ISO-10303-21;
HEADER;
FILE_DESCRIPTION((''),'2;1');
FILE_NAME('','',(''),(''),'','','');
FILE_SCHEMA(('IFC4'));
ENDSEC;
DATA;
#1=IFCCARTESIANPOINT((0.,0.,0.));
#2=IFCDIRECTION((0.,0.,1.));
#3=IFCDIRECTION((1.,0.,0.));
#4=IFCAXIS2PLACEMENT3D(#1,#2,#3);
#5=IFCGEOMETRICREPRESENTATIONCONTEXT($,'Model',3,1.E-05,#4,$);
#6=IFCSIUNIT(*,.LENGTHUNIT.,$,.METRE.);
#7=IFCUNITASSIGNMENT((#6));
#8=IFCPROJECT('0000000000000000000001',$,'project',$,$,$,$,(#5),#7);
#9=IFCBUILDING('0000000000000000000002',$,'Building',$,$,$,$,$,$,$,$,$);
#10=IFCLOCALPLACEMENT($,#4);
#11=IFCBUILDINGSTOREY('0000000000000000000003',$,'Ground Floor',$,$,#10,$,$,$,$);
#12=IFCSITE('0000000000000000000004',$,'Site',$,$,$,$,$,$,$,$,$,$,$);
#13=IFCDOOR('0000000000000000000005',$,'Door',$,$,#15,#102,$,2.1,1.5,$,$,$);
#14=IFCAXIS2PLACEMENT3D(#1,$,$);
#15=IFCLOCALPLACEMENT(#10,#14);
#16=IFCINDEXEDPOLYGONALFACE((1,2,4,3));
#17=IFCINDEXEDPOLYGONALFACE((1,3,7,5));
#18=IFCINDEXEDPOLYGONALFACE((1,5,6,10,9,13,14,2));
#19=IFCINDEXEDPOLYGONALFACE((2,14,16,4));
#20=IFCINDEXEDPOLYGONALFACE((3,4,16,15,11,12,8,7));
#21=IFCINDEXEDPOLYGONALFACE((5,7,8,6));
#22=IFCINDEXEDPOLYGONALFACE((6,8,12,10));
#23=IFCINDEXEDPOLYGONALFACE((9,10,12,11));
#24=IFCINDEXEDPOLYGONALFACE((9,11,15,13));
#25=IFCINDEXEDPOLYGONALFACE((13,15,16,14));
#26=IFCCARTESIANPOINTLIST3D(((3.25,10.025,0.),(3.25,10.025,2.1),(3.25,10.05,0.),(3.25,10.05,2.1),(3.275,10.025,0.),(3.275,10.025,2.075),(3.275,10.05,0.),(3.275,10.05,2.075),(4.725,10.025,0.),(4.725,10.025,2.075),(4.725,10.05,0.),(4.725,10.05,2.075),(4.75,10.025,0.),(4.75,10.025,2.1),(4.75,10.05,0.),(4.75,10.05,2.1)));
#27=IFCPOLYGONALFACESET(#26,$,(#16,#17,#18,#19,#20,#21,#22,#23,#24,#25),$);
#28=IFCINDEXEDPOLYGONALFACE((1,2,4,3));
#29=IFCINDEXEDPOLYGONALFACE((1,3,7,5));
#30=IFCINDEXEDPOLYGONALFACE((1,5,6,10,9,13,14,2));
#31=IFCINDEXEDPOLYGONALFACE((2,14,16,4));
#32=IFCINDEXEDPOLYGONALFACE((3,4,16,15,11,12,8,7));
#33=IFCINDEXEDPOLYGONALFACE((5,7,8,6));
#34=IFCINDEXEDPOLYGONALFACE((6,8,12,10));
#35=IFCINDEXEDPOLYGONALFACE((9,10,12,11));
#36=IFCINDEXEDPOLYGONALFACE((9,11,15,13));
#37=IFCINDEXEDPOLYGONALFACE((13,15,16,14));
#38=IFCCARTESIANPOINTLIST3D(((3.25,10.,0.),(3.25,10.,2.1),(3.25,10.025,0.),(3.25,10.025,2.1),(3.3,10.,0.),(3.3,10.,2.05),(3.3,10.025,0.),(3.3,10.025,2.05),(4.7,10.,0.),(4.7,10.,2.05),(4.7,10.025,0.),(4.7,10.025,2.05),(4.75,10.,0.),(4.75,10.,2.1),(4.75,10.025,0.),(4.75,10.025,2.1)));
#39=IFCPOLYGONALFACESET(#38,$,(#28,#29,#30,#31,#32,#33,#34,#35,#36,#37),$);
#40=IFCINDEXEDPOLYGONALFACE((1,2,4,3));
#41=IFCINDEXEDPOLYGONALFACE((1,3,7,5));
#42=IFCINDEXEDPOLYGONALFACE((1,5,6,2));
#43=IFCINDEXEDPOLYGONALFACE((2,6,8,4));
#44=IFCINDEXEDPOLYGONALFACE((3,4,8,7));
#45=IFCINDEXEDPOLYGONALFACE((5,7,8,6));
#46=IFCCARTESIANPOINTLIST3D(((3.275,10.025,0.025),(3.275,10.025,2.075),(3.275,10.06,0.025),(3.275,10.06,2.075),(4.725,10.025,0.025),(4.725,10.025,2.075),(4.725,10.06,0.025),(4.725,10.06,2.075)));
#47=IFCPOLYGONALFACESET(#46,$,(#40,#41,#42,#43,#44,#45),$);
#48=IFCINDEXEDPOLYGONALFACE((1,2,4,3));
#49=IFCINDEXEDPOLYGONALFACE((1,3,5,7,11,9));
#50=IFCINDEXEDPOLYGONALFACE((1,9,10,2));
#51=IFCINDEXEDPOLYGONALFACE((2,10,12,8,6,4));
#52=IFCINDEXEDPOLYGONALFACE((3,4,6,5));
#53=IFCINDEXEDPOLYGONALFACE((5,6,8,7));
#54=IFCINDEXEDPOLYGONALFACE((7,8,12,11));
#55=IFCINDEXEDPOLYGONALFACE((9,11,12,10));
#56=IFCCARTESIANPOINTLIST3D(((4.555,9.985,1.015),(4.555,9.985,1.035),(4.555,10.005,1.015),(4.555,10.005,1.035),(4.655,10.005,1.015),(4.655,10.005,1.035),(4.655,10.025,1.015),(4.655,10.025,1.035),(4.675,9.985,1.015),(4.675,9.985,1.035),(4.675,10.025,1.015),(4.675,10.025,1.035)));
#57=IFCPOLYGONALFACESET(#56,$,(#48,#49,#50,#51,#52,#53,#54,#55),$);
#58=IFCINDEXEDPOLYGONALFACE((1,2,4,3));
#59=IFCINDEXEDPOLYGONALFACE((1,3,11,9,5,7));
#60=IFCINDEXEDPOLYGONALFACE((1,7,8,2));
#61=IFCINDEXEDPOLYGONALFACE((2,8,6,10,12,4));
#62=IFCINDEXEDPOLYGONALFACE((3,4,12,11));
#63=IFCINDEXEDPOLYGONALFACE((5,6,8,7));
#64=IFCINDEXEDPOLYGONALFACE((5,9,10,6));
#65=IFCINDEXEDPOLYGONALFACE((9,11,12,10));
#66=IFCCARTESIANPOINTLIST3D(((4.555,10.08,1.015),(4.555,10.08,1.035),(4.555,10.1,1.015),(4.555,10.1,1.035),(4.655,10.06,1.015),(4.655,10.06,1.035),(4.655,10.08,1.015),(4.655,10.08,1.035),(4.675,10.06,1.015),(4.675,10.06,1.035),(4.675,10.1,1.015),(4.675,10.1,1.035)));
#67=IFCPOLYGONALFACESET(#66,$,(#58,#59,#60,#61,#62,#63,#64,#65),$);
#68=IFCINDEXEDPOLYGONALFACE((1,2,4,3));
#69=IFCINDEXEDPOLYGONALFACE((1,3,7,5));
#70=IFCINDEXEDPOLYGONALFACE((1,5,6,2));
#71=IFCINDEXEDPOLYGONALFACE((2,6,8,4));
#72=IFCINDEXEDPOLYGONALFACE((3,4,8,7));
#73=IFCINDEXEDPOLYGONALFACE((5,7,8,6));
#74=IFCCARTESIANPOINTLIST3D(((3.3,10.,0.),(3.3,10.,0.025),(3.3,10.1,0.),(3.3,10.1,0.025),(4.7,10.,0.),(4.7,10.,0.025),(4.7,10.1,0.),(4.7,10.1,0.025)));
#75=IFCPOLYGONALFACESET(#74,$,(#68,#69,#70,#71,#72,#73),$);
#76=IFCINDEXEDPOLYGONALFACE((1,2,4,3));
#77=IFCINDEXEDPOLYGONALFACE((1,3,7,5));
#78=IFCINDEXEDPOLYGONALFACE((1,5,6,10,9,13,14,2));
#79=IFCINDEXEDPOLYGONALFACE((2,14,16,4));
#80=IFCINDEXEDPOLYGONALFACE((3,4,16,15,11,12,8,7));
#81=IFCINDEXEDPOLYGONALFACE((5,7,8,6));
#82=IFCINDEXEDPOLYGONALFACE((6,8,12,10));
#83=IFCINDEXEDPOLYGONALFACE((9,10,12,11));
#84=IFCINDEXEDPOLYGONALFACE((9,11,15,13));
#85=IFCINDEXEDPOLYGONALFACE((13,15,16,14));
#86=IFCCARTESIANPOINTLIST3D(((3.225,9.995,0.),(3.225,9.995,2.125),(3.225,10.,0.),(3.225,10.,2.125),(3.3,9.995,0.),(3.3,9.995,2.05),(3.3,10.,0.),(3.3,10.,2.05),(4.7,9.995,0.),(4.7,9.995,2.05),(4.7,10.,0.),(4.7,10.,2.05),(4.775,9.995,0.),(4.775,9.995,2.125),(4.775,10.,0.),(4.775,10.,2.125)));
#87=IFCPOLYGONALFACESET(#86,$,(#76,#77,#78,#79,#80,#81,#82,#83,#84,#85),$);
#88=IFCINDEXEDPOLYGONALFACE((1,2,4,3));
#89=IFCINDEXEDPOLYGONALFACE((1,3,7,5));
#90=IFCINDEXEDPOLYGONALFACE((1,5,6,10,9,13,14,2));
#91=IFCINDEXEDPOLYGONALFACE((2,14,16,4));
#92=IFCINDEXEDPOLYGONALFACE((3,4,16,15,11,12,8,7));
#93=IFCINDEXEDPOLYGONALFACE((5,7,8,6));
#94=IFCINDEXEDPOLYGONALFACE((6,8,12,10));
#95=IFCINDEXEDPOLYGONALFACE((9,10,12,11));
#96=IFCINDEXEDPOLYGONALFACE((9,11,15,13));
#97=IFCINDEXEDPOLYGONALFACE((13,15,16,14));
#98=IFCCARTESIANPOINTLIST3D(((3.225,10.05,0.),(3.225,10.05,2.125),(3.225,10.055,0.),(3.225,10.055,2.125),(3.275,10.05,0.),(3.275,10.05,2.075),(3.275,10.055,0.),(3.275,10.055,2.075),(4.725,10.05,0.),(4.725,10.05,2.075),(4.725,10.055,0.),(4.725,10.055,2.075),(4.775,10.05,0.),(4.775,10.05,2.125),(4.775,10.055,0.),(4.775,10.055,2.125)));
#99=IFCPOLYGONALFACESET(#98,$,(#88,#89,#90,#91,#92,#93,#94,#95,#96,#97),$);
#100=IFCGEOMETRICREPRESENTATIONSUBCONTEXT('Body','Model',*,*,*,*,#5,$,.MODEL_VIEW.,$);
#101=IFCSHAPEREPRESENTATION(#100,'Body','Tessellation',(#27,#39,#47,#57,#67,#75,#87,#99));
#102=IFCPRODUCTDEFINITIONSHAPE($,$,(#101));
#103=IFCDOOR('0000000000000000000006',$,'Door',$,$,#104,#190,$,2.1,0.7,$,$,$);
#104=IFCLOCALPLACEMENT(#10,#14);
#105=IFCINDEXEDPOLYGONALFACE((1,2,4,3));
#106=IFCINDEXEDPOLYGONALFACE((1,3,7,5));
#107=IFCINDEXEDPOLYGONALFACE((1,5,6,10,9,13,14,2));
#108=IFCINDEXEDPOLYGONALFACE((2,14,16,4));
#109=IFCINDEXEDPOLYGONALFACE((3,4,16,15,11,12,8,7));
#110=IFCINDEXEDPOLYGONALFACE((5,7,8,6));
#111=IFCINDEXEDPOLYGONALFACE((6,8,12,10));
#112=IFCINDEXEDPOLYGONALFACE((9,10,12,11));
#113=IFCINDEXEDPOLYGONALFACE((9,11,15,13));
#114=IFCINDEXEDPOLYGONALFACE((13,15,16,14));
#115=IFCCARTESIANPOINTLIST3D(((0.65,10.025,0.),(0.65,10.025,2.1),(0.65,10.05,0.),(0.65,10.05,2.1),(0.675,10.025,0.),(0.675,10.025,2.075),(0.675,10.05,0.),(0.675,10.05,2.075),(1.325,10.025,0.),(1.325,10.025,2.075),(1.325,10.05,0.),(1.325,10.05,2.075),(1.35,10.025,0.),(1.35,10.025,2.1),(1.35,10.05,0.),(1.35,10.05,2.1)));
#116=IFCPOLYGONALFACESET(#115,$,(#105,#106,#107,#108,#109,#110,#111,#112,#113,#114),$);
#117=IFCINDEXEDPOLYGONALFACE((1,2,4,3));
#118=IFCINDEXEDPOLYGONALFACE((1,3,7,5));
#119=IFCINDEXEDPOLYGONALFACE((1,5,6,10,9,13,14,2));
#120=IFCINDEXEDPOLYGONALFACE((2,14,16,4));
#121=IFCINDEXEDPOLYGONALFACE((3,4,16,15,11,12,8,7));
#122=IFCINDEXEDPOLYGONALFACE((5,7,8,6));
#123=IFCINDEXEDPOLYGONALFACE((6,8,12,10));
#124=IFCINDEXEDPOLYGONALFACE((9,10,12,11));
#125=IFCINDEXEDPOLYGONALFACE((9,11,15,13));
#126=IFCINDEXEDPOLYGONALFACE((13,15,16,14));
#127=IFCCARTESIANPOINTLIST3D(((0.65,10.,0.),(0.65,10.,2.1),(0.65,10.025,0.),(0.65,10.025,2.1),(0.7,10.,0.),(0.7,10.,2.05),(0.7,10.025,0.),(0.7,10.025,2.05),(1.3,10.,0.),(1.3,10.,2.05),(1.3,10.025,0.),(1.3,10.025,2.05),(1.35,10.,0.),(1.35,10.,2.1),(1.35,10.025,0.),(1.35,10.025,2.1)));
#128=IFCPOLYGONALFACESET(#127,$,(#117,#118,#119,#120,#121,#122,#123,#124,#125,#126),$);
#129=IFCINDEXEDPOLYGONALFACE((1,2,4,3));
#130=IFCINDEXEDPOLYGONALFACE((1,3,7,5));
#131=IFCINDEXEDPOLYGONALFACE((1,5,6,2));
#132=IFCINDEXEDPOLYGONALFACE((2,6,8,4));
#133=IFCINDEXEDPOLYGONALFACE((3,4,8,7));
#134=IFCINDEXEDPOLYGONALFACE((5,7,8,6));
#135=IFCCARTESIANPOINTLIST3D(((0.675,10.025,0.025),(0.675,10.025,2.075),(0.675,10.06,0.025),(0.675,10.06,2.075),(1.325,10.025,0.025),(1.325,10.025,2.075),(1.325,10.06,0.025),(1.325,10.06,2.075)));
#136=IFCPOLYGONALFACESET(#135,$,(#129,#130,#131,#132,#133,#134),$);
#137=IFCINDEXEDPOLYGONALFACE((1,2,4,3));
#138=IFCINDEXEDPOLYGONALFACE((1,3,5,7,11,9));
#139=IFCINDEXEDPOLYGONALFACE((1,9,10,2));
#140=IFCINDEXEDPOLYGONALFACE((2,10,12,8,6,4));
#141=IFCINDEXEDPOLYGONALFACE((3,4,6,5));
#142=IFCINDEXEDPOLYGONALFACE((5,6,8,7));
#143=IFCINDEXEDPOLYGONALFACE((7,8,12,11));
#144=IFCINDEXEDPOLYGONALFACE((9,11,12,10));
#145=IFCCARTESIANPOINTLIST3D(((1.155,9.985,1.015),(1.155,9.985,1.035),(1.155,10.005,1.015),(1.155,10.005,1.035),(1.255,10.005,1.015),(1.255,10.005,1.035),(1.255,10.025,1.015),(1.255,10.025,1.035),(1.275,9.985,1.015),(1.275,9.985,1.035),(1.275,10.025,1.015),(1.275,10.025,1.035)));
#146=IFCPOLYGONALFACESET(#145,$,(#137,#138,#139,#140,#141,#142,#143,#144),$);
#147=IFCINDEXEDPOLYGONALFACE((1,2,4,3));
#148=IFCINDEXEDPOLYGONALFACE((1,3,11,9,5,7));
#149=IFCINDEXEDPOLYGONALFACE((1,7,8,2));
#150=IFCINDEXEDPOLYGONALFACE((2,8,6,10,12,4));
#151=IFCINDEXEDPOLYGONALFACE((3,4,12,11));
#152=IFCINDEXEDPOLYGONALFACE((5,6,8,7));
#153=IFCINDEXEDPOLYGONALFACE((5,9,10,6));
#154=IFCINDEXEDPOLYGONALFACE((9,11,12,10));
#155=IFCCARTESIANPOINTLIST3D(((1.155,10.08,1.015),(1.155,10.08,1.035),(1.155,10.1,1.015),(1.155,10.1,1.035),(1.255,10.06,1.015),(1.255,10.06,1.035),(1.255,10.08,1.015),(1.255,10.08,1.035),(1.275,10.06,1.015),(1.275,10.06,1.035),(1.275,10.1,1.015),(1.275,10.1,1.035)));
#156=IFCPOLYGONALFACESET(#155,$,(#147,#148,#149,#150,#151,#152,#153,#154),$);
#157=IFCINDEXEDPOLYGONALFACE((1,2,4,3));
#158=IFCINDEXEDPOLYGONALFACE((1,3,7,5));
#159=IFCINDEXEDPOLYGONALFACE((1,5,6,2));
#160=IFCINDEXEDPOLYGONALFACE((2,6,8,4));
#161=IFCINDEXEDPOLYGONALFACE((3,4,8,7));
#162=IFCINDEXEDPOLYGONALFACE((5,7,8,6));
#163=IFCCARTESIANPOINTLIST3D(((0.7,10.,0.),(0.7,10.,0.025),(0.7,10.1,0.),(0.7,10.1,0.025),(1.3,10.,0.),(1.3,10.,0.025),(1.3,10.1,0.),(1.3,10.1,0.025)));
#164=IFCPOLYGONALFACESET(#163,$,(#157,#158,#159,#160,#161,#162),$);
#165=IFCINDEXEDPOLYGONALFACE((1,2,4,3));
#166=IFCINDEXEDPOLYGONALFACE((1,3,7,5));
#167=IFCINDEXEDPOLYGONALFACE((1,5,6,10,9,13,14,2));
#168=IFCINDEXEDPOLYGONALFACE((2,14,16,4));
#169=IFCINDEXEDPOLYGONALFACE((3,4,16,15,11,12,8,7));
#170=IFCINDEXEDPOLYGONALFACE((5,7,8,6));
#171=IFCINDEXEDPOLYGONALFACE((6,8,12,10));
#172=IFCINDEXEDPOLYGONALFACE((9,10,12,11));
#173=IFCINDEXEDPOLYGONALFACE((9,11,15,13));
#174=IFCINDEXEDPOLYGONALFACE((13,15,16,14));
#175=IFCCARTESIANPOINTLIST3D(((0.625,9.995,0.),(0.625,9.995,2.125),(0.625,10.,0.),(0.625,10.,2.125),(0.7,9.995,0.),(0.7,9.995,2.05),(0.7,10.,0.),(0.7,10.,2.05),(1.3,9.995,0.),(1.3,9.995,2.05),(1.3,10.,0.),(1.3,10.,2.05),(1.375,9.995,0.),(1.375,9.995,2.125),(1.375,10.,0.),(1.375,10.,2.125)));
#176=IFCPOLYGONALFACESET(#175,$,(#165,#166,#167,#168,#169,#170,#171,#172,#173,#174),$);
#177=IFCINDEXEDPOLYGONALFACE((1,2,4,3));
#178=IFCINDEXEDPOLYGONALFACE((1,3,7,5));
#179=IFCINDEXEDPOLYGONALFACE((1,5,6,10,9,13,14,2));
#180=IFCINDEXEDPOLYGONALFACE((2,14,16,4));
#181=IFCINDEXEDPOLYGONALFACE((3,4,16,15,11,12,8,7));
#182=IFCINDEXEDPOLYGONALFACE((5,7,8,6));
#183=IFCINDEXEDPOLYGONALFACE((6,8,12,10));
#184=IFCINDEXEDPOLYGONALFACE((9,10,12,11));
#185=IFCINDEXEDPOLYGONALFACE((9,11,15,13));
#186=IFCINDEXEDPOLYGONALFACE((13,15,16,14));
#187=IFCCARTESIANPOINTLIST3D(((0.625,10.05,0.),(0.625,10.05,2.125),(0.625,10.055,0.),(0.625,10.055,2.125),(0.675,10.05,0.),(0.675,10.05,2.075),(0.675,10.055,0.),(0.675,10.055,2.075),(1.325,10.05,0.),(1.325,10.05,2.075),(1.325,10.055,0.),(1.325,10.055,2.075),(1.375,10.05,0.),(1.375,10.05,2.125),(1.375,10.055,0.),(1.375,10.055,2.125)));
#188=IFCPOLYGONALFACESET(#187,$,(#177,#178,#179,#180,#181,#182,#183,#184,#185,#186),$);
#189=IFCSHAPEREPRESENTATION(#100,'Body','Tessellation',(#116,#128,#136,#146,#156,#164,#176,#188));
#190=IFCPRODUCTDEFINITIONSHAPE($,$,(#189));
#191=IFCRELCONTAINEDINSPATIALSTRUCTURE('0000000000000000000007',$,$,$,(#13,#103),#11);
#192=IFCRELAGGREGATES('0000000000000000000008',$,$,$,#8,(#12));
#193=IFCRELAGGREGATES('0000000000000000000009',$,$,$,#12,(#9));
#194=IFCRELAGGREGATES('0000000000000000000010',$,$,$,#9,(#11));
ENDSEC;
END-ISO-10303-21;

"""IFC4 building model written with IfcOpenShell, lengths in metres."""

from ifc_helpers import new_model, si_unit, frame, origin_with_axes, place, context, subcontext, project, spatial, line, indexed_curve, outline, extrude, element, save


model = new_model("IFC4")

# Units and contexts
model_context = context("Model", 3, precision=1e-05, world=origin_with_axes())
body_context = subcontext(model_context, "Body", "Model", "MODEL_VIEW")
ifc_project = project(units=[si_unit("LENGTHUNIT", "METRE")], contexts=[model_context])

# Site, building, storey
site = spatial("IfcSite", under=ifc_project, Name="Site")
building = spatial("IfcBuilding", under=site, Name="Building")
storey_placement = place(None, origin_with_axes())
storey = spatial("IfcBuildingStorey", under=building, at=storey_placement, Name="Ground Floor")

# Doors
door_1_placement = place(storey_placement, frame((3.25, 10.0, 0.0), z_axis=(0.0, 0.0, 1.0), x_axis=(1.0, 0.0, 0.0)))
element("IfcDoor", 1, at=door_1_placement, inside=storey, Name="Door", OverallHeight=2.1, OverallWidth=1.5, context=body_context, shape_type="SweptSolid", body=[
    extrude(outline(indexed_curve([(0.0, 0.0), (0.0, 2.1), (1.5, 2.1), (1.5, 0.0), (1.475, 0.0), (1.475, 2.075), (0.025, 2.075), (0.025, 0.0)], segments=[line(1, 2, 3, 4, 5, 6, 7, 8, 1)])), frame((0.0, 0.025, 0.0), z_axis=(0.0, -1.0, 0.0), x_axis=(1.0, 0.0, 0.0)), (0.0, 0.0, -1.0), 0.025),
    extrude(outline(indexed_curve([(0.0, 0.0), (0.0, 2.1), (1.5, 2.1), (1.5, 0.0), (1.45, 0.0), (1.45, 2.05), (0.05, 2.05), (0.05, 0.0)], segments=[line(1, 2, 3, 4, 5, 6, 7, 8, 1)])), frame((0.0, 0.0, 0.0), z_axis=(0.0, -1.0, 0.0), x_axis=(1.0, 0.0, 0.0)), (0.0, 0.0, -1.0), 0.025),
    extrude(outline(indexed_curve([(0.0, 0.0), (1.45, 0.0), (1.45, 0.035), (0.0, 0.035)], segments=[line(1, 2, 3, 4, 1)])), frame((0.025, 0.025, 0.025), z_axis=(0.0, 0.0, 1.0), x_axis=(1.0, 0.0, 0.0)), (0.0, 0.0, 1.0), 2.05),
    extrude(outline(indexed_curve([(0.0, 0.0), (0.0, -0.04), (-0.12, -0.04), (-0.12, -0.02), (-0.02, -0.02), (-0.02, 0.0)], segments=[line(1, 2, 3, 4, 5, 6, 1)])), frame((1.425, 0.025, 1.015), z_axis=(0.0, 0.0, 1.0), x_axis=(1.0, 0.0, 0.0)), (0.0, 0.0, 1.0), 0.02),
    extrude(outline(indexed_curve([(0.0, 0.0), (0.0, 0.04), (-0.12, 0.04), (-0.12, 0.02), (-0.02, 0.02), (-0.02, 0.0)], segments=[line(1, 2, 3, 4, 5, 6, 1)])), frame((1.425, 0.06, 1.015), z_axis=(0.0, 0.0, 1.0), x_axis=(1.0, 0.0, 0.0)), (0.0, 0.0, 1.0), 0.02),
    extrude(outline(indexed_curve([(0.0, 0.0), (1.4, 0.0), (1.4, 0.1), (0.0, 0.1)], segments=[line(1, 2, 3, 4, 1)])), frame((0.05, 0.0, 0.0), z_axis=(0.0, 0.0, 1.0), x_axis=(1.0, 0.0, 0.0)), (0.0, 0.0, 1.0), 0.025),
    extrude(outline(indexed_curve([(0.0, 0.0), (0.0, 2.125), (1.55, 2.125), (1.55, 0.0), (1.475, 0.0), (1.475, 2.05), (0.075, 2.05), (0.075, 0.0)], segments=[line(1, 2, 3, 4, 5, 6, 7, 8, 1)])), frame((-0.025, -0.005, 0.0), z_axis=(0.0, -1.0, 0.0), x_axis=(1.0, 0.0, 0.0)), (0.0, 0.0, -1.0), 0.005),
    extrude(outline(indexed_curve([(0.0, 0.0), (0.0, 2.125), (1.55, 2.125), (1.55, 0.0), (1.5, 0.0), (1.5, 2.075), (0.05, 2.075), (0.05, 0.0)], segments=[line(1, 2, 3, 4, 5, 6, 7, 8, 1)])), frame((-0.025, 0.05, 0.0), z_axis=(0.0, -1.0, 0.0), x_axis=(1.0, 0.0, 0.0)), (0.0, 0.0, -1.0), 0.005),
])
door_2_placement = place(storey_placement, frame((0.65, 10.0, 0.0), z_axis=(0.0, 0.0, 1.0), x_axis=(1.0, 0.0, 0.0)))
element("IfcDoor", 2, at=door_2_placement, inside=storey, Name="Door", OverallHeight=2.1, OverallWidth=0.7, context=body_context, shape_type="SweptSolid", body=[
    extrude(outline(indexed_curve([(0.0, 0.0), (0.0, 2.1), (0.7, 2.1), (0.7, 0.0), (0.675, 0.0), (0.675, 2.075), (0.025, 2.075), (0.025, 0.0)], segments=[line(1, 2, 3, 4, 5, 6, 7, 8, 1)])), frame((0.0, 0.025, 0.0), z_axis=(0.0, -1.0, 0.0), x_axis=(1.0, 0.0, 0.0)), (0.0, 0.0, -1.0), 0.025),
    extrude(outline(indexed_curve([(0.0, 0.0), (0.0, 2.1), (0.7, 2.1), (0.7, 0.0), (0.65, 0.0), (0.65, 2.05), (0.05, 2.05), (0.05, 0.0)], segments=[line(1, 2, 3, 4, 5, 6, 7, 8, 1)])), frame((0.0, 0.0, 0.0), z_axis=(0.0, -1.0, 0.0), x_axis=(1.0, 0.0, 0.0)), (0.0, 0.0, -1.0), 0.025),
    extrude(outline(indexed_curve([(0.0, 0.0), (0.65, 0.0), (0.65, 0.035), (0.0, 0.035)], segments=[line(1, 2, 3, 4, 1)])), frame((0.025, 0.025, 0.025), z_axis=(0.0, 0.0, 1.0), x_axis=(1.0, 0.0, 0.0)), (0.0, 0.0, 1.0), 2.05),
    extrude(outline(indexed_curve([(0.0, 0.0), (0.0, -0.04), (-0.12, -0.04), (-0.12, -0.02), (-0.02, -0.02), (-0.02, 0.0)], segments=[line(1, 2, 3, 4, 5, 6, 1)])), frame((0.625, 0.025, 1.015), z_axis=(0.0, 0.0, 1.0), x_axis=(1.0, 0.0, 0.0)), (0.0, 0.0, 1.0), 0.02),
    extrude(outline(indexed_curve([(0.0, 0.0), (0.0, 0.04), (-0.12, 0.04), (-0.12, 0.02), (-0.02, 0.02), (-0.02, 0.0)], segments=[line(1, 2, 3, 4, 5, 6, 1)])), frame((0.625, 0.06, 1.015), z_axis=(0.0, 0.0, 1.0), x_axis=(1.0, 0.0, 0.0)), (0.0, 0.0, 1.0), 0.02),
    extrude(outline(indexed_curve([(0.0, 0.0), (0.6, 0.0), (0.6, 0.1), (0.0, 0.1)], segments=[line(1, 2, 3, 4, 1)])), frame((0.05, 0.0, 0.0), z_axis=(0.0, 0.0, 1.0), x_axis=(1.0, 0.0, 0.0)), (0.0, 0.0, 1.0), 0.025),
    extrude(outline(indexed_curve([(0.0, 0.0), (0.0, 2.125), (0.75, 2.125), (0.75, 0.0), (0.675, 0.0), (0.675, 2.05), (0.075, 2.05), (0.075, 0.0)], segments=[line(1, 2, 3, 4, 5, 6, 7, 8, 1)])), frame((-0.025, -0.005, 0.0), z_axis=(0.0, -1.0, 0.0), x_axis=(1.0, 0.0, 0.0)), (0.0, 0.0, -1.0), 0.005),
    extrude(outline(indexed_curve([(0.0, 0.0), (0.0, 2.125), (0.75, 2.125), (0.75, 0.0), (0.7, 0.0), (0.7, 2.075), (0.05, 2.075), (0.05, 0.0)], segments=[line(1, 2, 3, 4, 5, 6, 7, 8, 1)])), frame((-0.025, 0.05, 0.0), z_axis=(0.0, -1.0, 0.0), x_axis=(1.0, 0.0, 0.0)), (0.0, 0.0, -1.0), 0.005),
])

save(model, "model.ifc")
